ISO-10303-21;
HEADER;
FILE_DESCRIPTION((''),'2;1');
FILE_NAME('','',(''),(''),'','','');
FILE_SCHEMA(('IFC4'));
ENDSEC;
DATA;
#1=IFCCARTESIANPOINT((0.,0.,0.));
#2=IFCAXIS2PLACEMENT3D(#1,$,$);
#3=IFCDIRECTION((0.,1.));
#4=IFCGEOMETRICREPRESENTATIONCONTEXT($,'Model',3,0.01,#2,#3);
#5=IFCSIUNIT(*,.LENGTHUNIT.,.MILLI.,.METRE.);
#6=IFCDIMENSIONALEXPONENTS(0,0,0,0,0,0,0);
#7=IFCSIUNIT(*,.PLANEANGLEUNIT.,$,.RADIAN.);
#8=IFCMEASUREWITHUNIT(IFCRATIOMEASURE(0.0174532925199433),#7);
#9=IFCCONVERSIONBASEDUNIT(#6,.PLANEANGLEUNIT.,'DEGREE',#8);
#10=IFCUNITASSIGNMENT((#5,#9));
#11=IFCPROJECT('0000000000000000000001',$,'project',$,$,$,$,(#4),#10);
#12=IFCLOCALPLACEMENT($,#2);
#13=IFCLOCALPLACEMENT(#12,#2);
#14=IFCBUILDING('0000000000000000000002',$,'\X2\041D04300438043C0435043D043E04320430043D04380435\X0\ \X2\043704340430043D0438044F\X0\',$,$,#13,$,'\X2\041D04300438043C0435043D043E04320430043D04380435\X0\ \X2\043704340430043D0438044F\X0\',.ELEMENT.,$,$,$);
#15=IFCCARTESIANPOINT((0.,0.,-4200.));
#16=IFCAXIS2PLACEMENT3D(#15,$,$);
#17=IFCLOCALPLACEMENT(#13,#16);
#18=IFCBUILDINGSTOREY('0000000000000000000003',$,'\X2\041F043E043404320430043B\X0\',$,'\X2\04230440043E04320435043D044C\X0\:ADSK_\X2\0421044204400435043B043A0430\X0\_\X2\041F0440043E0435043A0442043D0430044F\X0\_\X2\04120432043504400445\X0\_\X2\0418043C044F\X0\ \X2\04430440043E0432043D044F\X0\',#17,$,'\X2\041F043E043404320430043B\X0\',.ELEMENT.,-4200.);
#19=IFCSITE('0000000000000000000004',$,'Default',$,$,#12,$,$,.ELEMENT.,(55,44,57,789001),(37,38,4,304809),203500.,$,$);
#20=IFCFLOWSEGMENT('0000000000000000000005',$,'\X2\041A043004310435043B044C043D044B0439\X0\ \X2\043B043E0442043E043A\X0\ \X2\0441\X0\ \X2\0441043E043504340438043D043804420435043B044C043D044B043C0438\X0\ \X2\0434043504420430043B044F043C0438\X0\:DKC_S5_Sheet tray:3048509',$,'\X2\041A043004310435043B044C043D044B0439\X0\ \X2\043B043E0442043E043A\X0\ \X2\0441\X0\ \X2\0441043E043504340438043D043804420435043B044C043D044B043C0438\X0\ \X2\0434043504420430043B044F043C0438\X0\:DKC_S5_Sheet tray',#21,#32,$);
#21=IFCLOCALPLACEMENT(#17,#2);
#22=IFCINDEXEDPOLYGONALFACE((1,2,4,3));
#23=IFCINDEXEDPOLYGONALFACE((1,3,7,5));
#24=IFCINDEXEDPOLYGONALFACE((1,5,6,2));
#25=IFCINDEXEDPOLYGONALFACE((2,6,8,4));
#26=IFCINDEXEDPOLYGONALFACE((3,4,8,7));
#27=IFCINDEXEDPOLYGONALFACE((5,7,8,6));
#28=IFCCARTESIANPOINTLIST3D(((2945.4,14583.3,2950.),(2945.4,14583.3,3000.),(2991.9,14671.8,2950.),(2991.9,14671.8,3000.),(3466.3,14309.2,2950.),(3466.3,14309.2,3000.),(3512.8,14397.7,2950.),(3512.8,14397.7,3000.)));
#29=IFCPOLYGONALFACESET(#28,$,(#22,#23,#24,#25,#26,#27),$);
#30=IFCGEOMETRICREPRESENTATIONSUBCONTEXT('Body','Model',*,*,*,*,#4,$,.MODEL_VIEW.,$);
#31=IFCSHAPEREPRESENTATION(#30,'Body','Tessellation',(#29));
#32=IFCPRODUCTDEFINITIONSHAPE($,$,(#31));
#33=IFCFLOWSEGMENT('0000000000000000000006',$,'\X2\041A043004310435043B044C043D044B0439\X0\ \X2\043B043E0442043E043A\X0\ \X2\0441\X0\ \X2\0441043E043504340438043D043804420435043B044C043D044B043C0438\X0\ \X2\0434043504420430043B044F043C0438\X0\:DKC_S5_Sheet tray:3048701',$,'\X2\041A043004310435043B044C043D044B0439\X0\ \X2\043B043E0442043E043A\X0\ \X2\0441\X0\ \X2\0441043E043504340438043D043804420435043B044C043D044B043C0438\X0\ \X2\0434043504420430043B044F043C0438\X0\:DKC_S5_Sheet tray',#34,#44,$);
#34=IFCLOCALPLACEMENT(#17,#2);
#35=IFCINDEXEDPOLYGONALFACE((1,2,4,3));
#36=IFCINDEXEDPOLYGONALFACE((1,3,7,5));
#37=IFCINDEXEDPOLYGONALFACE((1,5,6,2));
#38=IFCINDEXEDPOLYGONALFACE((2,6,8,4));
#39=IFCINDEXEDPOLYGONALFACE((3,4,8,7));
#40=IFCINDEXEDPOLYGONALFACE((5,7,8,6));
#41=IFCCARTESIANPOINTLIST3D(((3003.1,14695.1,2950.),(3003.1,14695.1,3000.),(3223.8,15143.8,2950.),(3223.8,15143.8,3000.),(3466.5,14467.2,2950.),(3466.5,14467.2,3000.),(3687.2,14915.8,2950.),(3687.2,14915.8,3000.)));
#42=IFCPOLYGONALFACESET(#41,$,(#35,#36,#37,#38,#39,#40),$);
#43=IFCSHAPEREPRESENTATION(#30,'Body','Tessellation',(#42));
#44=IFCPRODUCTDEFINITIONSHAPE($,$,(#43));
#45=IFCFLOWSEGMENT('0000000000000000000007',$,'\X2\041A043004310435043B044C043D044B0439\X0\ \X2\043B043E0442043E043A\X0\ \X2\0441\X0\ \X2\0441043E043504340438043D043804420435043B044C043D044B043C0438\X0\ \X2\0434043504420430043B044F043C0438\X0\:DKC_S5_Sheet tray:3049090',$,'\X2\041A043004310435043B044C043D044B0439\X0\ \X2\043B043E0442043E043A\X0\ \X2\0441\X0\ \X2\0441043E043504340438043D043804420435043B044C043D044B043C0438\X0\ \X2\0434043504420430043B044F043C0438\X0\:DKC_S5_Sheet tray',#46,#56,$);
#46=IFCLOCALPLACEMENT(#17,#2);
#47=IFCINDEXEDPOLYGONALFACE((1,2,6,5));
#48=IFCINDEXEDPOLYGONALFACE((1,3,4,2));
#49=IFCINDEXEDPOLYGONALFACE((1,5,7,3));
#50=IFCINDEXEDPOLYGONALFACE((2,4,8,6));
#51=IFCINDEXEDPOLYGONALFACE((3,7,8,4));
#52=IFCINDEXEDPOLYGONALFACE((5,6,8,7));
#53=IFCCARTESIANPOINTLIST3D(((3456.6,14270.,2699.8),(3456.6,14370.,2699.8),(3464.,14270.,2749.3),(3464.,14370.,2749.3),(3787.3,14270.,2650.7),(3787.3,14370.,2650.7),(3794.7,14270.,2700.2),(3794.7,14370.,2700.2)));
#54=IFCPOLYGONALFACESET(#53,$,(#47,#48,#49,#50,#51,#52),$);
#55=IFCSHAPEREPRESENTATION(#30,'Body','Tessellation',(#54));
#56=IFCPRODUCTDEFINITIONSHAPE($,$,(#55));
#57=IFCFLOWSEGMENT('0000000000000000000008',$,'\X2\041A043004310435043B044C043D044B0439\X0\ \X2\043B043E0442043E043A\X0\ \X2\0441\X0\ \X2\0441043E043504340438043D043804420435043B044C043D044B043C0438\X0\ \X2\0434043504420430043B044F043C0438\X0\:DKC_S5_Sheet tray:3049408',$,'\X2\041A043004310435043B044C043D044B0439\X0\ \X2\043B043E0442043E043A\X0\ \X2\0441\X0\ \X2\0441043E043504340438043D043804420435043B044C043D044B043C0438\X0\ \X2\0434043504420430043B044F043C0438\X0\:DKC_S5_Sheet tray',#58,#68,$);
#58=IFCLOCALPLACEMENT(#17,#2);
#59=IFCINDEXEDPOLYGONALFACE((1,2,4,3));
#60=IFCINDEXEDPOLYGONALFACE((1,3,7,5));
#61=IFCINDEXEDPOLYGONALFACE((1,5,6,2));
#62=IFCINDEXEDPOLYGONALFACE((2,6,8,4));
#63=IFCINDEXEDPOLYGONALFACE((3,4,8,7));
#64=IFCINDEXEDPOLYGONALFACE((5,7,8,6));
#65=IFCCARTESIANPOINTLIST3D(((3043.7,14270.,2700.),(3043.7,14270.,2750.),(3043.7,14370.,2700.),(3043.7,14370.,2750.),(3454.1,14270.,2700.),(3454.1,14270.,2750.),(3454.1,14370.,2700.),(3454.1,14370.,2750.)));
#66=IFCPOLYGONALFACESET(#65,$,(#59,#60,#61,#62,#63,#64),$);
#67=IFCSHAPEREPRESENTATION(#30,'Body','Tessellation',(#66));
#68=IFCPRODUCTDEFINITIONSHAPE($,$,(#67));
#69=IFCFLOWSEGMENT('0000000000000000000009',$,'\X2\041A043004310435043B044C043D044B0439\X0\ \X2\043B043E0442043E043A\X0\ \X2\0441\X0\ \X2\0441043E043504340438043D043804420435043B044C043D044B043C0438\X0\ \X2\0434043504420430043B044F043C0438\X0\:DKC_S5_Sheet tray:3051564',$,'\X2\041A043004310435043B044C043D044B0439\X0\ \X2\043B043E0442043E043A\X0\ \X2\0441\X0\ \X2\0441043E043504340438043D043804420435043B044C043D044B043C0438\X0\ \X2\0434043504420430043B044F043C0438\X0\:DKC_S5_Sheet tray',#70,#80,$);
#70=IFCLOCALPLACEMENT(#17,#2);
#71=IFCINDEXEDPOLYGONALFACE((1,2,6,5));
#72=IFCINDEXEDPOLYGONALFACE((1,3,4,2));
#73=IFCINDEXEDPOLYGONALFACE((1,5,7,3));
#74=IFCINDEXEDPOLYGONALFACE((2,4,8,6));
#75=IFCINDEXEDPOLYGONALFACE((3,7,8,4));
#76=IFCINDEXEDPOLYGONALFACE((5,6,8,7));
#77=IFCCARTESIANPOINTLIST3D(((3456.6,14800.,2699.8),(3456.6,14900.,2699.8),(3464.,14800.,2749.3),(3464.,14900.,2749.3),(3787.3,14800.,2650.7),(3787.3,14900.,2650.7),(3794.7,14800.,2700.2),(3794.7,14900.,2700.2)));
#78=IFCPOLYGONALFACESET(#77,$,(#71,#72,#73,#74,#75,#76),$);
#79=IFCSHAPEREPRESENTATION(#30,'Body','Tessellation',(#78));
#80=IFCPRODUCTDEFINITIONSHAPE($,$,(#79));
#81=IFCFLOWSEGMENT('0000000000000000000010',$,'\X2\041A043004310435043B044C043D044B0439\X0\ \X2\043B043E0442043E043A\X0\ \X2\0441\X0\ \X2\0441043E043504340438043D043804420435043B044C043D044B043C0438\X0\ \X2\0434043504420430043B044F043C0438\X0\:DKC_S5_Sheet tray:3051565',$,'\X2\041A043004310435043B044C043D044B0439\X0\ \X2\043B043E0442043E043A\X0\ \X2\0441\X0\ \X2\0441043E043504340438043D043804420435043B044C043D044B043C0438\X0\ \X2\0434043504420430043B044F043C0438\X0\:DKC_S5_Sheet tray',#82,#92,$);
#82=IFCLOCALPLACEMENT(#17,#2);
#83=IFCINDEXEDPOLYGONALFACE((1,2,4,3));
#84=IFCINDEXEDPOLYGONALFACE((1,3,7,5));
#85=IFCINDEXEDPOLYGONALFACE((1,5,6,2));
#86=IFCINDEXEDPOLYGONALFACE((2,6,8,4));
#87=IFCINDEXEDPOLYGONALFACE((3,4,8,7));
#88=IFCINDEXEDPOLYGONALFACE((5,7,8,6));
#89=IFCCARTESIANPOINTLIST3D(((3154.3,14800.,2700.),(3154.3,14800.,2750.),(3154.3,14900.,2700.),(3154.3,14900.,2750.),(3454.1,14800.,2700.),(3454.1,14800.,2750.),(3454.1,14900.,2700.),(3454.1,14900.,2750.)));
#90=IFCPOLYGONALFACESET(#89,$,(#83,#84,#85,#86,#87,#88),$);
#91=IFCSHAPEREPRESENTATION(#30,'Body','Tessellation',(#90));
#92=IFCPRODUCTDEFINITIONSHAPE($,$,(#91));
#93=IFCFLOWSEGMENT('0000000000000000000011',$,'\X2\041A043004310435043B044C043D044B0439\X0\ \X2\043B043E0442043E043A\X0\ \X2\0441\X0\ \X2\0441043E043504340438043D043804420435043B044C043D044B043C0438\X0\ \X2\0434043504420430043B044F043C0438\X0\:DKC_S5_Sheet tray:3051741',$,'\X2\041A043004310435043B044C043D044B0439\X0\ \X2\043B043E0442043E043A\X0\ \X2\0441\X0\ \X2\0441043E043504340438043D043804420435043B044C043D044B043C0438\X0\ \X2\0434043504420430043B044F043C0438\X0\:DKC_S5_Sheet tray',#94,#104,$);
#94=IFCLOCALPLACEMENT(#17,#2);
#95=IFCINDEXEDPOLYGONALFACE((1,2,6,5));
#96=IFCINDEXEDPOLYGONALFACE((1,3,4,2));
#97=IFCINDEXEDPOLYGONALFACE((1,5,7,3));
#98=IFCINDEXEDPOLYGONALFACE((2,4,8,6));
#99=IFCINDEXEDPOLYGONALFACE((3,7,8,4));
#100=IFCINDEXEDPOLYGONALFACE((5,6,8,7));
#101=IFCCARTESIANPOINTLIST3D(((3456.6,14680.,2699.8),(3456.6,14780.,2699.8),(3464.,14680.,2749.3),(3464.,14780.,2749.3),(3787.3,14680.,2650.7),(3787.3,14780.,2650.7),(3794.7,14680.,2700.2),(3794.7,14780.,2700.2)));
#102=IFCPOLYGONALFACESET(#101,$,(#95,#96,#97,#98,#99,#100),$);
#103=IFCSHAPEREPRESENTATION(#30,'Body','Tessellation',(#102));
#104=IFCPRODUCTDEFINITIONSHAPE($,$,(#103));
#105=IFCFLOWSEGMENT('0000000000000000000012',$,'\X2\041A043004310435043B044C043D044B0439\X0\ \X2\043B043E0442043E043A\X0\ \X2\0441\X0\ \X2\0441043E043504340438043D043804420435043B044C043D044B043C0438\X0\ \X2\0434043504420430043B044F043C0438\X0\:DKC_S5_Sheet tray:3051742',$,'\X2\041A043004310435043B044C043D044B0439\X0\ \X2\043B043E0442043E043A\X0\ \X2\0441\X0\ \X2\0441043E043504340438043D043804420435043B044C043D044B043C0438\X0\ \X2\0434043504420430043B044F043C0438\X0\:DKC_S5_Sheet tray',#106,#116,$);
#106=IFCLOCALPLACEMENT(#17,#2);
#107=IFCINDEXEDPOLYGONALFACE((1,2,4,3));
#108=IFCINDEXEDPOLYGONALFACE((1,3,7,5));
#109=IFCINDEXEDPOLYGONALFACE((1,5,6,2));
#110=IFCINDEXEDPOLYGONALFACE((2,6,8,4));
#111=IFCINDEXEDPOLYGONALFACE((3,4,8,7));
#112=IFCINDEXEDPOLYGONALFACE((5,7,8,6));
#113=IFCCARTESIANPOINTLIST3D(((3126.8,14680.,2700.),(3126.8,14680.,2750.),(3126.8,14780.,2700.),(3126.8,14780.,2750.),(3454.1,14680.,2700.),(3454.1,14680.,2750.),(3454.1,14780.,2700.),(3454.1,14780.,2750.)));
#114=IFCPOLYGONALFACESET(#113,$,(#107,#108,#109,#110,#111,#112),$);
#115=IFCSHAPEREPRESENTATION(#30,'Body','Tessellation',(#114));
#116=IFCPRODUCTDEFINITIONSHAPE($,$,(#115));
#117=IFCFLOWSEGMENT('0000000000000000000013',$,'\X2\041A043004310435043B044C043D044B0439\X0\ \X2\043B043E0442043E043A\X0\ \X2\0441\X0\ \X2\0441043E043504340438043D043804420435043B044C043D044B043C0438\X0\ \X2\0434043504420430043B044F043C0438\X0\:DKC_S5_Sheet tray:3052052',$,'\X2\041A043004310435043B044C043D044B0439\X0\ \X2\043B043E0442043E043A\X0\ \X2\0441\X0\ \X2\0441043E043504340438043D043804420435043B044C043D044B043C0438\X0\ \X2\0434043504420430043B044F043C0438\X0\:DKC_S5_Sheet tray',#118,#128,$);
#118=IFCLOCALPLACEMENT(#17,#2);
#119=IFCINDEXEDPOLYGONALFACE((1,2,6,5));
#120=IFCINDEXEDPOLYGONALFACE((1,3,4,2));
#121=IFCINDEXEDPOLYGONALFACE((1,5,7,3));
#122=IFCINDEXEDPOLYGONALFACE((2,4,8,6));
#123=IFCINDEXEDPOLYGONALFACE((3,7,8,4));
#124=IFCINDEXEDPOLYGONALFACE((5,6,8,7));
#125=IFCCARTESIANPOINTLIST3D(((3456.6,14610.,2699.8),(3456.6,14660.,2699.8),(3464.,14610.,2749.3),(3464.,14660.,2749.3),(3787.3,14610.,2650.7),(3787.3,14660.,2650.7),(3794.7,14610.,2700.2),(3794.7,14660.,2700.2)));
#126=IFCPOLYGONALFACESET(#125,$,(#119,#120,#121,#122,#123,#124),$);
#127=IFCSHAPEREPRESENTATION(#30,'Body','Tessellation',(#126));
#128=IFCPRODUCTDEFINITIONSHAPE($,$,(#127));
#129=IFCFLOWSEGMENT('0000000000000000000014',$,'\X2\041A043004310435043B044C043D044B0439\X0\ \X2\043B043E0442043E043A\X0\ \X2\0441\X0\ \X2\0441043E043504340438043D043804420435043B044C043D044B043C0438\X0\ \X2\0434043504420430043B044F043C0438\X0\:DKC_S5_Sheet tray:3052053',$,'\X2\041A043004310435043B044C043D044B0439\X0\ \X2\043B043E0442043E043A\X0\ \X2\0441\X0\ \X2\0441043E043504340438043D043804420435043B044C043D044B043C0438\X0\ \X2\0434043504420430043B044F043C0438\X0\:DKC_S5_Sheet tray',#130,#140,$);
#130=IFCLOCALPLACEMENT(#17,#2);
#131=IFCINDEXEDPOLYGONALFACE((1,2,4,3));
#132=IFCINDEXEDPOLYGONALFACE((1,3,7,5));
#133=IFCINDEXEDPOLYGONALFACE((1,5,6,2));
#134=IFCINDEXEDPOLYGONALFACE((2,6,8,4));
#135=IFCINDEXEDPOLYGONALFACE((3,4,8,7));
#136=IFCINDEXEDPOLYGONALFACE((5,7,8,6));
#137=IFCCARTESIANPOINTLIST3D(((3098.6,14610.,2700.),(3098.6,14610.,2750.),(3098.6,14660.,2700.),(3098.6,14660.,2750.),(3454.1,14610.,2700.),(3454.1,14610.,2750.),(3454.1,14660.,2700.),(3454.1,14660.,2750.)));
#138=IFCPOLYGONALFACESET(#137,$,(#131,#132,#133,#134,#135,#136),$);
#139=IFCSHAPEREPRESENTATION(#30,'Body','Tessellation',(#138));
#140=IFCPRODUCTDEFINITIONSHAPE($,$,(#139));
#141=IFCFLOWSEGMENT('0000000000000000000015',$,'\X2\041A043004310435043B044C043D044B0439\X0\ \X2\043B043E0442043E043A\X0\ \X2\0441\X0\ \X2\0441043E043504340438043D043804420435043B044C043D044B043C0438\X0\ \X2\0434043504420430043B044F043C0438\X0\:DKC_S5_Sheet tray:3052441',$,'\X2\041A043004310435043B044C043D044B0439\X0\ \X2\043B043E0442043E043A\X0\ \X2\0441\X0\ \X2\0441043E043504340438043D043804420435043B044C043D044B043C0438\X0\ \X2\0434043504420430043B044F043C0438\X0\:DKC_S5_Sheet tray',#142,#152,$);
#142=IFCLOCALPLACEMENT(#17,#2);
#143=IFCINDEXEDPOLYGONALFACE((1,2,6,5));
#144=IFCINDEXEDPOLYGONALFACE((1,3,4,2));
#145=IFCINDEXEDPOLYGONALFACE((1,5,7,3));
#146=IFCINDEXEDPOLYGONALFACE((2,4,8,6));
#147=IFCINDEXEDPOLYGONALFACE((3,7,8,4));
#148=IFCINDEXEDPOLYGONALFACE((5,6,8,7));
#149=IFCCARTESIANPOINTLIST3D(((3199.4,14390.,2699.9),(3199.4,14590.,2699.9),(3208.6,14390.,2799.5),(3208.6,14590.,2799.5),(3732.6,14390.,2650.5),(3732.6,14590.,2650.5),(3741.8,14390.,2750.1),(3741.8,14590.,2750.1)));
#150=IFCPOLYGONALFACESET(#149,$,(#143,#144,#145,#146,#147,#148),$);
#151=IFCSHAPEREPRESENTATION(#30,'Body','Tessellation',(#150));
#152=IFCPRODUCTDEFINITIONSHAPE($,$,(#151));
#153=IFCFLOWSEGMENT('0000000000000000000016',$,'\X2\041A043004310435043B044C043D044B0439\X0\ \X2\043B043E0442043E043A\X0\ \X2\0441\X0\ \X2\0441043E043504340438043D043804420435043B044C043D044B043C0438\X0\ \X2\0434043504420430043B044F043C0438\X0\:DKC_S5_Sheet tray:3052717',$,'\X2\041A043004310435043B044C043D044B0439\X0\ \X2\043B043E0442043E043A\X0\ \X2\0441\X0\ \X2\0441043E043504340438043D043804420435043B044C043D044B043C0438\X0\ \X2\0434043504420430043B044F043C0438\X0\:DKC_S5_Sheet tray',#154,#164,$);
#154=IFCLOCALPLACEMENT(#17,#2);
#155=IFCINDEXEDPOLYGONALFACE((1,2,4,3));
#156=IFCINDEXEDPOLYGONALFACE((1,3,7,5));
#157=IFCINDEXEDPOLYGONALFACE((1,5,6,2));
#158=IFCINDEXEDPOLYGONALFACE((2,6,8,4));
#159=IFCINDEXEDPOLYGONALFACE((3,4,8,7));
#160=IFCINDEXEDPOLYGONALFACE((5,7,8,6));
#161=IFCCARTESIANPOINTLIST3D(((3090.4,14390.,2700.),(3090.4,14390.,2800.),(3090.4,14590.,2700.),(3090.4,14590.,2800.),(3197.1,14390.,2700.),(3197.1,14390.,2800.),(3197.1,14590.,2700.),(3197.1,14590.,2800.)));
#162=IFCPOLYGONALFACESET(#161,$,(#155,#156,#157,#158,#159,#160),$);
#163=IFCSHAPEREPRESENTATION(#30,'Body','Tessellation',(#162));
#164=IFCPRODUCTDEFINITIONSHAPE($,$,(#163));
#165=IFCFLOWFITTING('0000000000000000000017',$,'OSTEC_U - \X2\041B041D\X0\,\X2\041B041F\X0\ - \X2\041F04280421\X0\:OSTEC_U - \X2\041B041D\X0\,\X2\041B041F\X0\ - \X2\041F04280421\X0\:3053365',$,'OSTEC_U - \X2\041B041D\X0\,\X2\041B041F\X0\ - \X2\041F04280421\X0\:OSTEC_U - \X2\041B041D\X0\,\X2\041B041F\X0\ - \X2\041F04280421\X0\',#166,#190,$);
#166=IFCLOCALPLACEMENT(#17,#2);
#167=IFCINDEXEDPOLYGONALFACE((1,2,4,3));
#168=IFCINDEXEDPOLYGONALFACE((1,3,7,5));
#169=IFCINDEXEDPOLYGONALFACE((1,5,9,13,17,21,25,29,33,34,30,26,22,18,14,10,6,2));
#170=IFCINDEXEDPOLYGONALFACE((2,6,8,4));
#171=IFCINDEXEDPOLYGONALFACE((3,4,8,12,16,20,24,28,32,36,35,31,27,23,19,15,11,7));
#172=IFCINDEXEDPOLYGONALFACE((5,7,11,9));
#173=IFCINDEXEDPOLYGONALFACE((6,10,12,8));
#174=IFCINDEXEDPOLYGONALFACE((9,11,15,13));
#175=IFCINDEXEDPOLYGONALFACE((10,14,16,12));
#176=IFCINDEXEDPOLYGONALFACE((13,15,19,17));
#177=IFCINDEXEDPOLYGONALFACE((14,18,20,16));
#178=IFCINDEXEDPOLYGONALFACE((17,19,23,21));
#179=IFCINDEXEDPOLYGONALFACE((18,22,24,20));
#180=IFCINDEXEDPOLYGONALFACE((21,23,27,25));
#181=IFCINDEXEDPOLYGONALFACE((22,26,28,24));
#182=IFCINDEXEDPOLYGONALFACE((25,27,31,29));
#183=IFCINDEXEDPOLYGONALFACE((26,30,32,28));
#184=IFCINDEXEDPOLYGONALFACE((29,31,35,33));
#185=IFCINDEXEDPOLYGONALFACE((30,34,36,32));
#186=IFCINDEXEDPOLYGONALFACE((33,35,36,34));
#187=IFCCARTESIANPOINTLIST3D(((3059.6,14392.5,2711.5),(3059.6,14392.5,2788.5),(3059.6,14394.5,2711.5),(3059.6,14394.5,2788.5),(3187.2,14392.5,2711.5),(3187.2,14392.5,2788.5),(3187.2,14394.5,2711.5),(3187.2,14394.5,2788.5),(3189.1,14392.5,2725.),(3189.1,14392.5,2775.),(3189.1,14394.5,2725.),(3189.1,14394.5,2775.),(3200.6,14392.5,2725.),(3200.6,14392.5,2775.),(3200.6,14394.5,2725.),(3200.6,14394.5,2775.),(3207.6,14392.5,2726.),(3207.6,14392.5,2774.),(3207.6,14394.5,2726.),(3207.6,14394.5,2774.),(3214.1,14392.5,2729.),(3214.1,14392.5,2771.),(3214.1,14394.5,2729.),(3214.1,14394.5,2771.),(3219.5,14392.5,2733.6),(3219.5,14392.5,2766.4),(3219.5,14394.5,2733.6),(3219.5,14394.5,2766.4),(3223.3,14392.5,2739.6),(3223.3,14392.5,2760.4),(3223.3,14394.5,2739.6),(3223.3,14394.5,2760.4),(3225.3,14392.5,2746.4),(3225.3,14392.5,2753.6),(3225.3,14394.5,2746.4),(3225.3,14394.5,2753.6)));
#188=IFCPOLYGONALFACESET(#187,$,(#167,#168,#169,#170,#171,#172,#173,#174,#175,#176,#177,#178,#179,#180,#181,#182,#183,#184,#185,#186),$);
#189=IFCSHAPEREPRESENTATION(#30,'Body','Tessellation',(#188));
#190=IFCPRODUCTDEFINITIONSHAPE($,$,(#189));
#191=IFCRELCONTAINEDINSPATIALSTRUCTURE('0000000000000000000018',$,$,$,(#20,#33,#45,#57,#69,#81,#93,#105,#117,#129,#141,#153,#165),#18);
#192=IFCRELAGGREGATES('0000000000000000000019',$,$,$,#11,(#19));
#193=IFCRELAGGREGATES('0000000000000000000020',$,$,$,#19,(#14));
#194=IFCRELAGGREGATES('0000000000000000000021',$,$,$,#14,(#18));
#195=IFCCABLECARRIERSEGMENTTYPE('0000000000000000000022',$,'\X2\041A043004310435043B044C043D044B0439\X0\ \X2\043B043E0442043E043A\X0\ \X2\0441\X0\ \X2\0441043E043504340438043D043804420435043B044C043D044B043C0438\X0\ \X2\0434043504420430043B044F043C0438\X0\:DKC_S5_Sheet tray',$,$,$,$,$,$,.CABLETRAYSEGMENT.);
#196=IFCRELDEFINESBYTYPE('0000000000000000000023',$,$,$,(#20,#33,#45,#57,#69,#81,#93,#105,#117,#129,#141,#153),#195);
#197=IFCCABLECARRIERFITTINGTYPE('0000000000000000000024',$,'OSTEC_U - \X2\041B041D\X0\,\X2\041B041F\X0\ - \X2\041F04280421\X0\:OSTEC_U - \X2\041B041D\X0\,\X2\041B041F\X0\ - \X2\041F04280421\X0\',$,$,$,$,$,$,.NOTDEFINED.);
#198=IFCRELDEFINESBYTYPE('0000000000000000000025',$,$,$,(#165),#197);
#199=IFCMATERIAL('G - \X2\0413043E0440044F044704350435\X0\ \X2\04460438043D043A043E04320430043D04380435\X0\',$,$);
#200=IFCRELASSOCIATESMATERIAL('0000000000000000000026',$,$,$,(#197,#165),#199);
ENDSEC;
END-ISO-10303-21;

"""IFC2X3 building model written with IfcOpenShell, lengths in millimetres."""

from ifc_helpers import new_model, entity, si_unit, converted_unit, direction, frame, frame_2d, origin, origin_2d_with_axis, place, context, subcontext, project, spatial, polyline, circle_curve, parameter, trimmed, segment, composite_curve, rectangle, outline, extrude, source, transform, mapped, material, type_object, type_shapes, element, save


model = new_model("IFC2X3")

# Units and contexts
model_context = context("Model", 3, precision=0.01, world=origin(), true_north=direction((0.0, 1.0)))
body_context = subcontext(model_context, "Body", "Model", "MODEL_VIEW")
ifc_project = project(units=[si_unit("LENGTHUNIT", "METRE", prefix="MILLI"), converted_unit("PLANEANGLEUNIT", "DEGREE", entity("IfcRatioMeasure", 0.0174532925199433), si_unit("PLANEANGLEUNIT", "RADIAN"), dimensions=[0, 0, 0, 0, 0, 0, 0])], contexts=[model_context])

# Site, building, storey
site_placement = place(None, origin())
site = spatial("IfcSite", under=ifc_project, at=site_placement, Name="Default", CompositionType="ELEMENT", RefLatitude=(55, 44, 57, 789001), RefLongitude=(37, 38, 4, 304809), RefElevation=203500.0)
building_placement = place(site_placement, origin())
building = spatial("IfcBuilding", under=site, at=building_placement, Name="Наименование здания", LongName="Наименование здания", CompositionType="ELEMENT")
storey_placement = place(building_placement, frame((0.0, 0.0, -4200.0)))
storey = spatial("IfcBuildingStorey", under=building, at=storey_placement, Name="Подвал", ObjectType="Уровень:ADSK_Стрелка_Проектная_Вверх_Имя уровня", LongName="Подвал", CompositionType="ELEMENT", Elevation=-4200.0)

# Flow segments
cable_carrier_segment_type = type_object("IfcCableCarrierSegmentType", Name="Кабельный лоток с соединительными деталями:DKC_S5_Sheet tray", PredefinedType="CABLETRAYSEGMENT")
flow_segment_1_placement = place(storey_placement, frame((2945.4, 14309.2, 2950.0)))
element("IfcFlowSegment", 1, at=flow_segment_1_placement, inside=storey, type_object=cable_carrier_segment_type, Name="Кабельный лоток с соединительными деталями:DKC_S5_Sheet tray:3048509", ObjectType="Кабельный лоток с соединительными деталями:DKC_S5_Sheet tray", context=body_context, shape_type="SweptSolid", body=[
    extrude(rectangle(XDim=588.6, YDim=100.0, at=origin_2d_with_axis()), frame((283.7, 181.3, 0.0), z_axis=(0.0, 0.0, 1.0), x_axis=(0.885007, -0.465578, 0.0)), (0.0, 0.0, 1.0), 50.0),
])
flow_segment_2_placement = place(storey_placement, frame((3003.1, 14467.2, 2950.0)))
element("IfcFlowSegment", 2, at=flow_segment_2_placement, inside=storey, type_object=cable_carrier_segment_type, Name="Кабельный лоток с соединительными деталями:DKC_S5_Sheet tray:3048701", ObjectType="Кабельный лоток с соединительными деталями:DKC_S5_Sheet tray", context=body_context, shape_type="SweptSolid", body=[
    extrude(rectangle(XDim=516.5, YDim=500.0, at=origin_2d_with_axis()), frame((342.1, 338.3, 0.0), z_axis=(0.0, 0.0, 1.0), x_axis=(0.897336, -0.441348, 0.0)), (0.0, 0.0, 1.0), 50.0),
])
flow_segment_3_placement = place(storey_placement, frame((3456.6, 14270.0, 2650.7)))
element("IfcFlowSegment", 3, at=flow_segment_3_placement, inside=storey, type_object=cable_carrier_segment_type, Name="Кабельный лоток с соединительными деталями:DKC_S5_Sheet tray:3049090", ObjectType="Кабельный лоток с соединительными деталями:DKC_S5_Sheet tray", context=body_context, shape_type="SweptSolid", body=[
    extrude(rectangle(XDim=50.0, YDim=100.0, at=origin_2d_with_axis()), frame((3.7, 50.0, 73.8), z_axis=(0.989166, 0.0, -0.1468), x_axis=(0.1468, 0.0, 0.989166)), (0.0, 0.0, 1.0), 334.3),
])
flow_segment_4_placement = place(storey_placement, frame((3043.8, 14270.0, 2700.0)))
element("IfcFlowSegment", 4, at=flow_segment_4_placement, inside=storey, type_object=cable_carrier_segment_type, Name="Кабельный лоток с соединительными деталями:DKC_S5_Sheet tray:3049408", ObjectType="Кабельный лоток с соединительными деталями:DKC_S5_Sheet tray", context=body_context, shape_type="SweptSolid", body=[
    extrude(rectangle(XDim=410.3, YDim=100.0, at=origin_2d_with_axis()), frame((205.2, 50.0, 0.0), z_axis=(0.0, 0.0, 1.0), x_axis=(-1.0, 0.0, 0.0)), (0.0, 0.0, 1.0), 50.0),
])
flow_segment_5_placement = place(storey_placement, frame((3456.6, 14800.0, 2650.7)))
element("IfcFlowSegment", 5, at=flow_segment_5_placement, inside=storey, type_object=cable_carrier_segment_type, Name="Кабельный лоток с соединительными деталями:DKC_S5_Sheet tray:3051564", ObjectType="Кабельный лоток с соединительными деталями:DKC_S5_Sheet tray", context=body_context, shape_type="SweptSolid", body=[
    extrude(rectangle(XDim=50.0, YDim=100.0, at=origin_2d_with_axis()), frame((3.7, 50.0, 73.8), z_axis=(0.989166, 0.0, -0.1468), x_axis=(0.1468, 0.0, 0.989166)), (0.0, 0.0, 1.0), 334.3),
])
flow_segment_6_placement = place(storey_placement, frame((3154.3, 14800.0, 2700.0)))
element("IfcFlowSegment", 6, at=flow_segment_6_placement, inside=storey, type_object=cable_carrier_segment_type, Name="Кабельный лоток с соединительными деталями:DKC_S5_Sheet tray:3051565", ObjectType="Кабельный лоток с соединительными деталями:DKC_S5_Sheet tray", context=body_context, shape_type="SweptSolid", body=[
    extrude(rectangle(XDim=299.7, YDim=100.0, at=origin_2d_with_axis()), frame((149.9, 50.0, 0.0), z_axis=(0.0, 0.0, 1.0), x_axis=(-1.0, 0.0, 0.0)), (0.0, 0.0, 1.0), 50.0),
])
flow_segment_7_placement = place(storey_placement, frame((3456.6, 14680.0, 2650.7)))
element("IfcFlowSegment", 7, at=flow_segment_7_placement, inside=storey, type_object=cable_carrier_segment_type, Name="Кабельный лоток с соединительными деталями:DKC_S5_Sheet tray:3051741", ObjectType="Кабельный лоток с соединительными деталями:DKC_S5_Sheet tray", context=body_context, shape_type="SweptSolid", body=[
    extrude(rectangle(XDim=50.0, YDim=100.0, at=origin_2d_with_axis()), frame((3.7, 50.0, 73.8), z_axis=(0.989166, 0.0, -0.1468), x_axis=(0.1468, 0.0, 0.989166)), (0.0, 0.0, 1.0), 334.3),
])
flow_segment_8_placement = place(storey_placement, frame((3126.8, 14680.0, 2700.0)))
element("IfcFlowSegment", 8, at=flow_segment_8_placement, inside=storey, type_object=cable_carrier_segment_type, Name="Кабельный лоток с соединительными деталями:DKC_S5_Sheet tray:3051742", ObjectType="Кабельный лоток с соединительными деталями:DKC_S5_Sheet tray", context=body_context, shape_type="SweptSolid", body=[
    extrude(rectangle(XDim=327.2, YDim=100.0, at=origin_2d_with_axis()), frame((163.6, 50.0, 0.0), z_axis=(0.0, 0.0, 1.0), x_axis=(-1.0, 0.0, 0.0)), (0.0, 0.0, 1.0), 50.0),
])
flow_segment_9_placement = place(storey_placement, frame((3456.6, 14610.0, 2650.7)))
element("IfcFlowSegment", 9, at=flow_segment_9_placement, inside=storey, type_object=cable_carrier_segment_type, Name="Кабельный лоток с соединительными деталями:DKC_S5_Sheet tray:3052052", ObjectType="Кабельный лоток с соединительными деталями:DKC_S5_Sheet tray", context=body_context, shape_type="SweptSolid", body=[
    extrude(rectangle(XDim=50.0, YDim=50.0, at=origin_2d_with_axis()), frame((3.7, 25.0, 73.8), z_axis=(0.989166, 0.0, -0.1468), x_axis=(0.1468, 0.0, 0.989166)), (0.0, 0.0, 1.0), 334.3),
])
flow_segment_10_placement = place(storey_placement, frame((3098.6, 14610.0, 2700.0)))
element("IfcFlowSegment", 10, at=flow_segment_10_placement, inside=storey, type_object=cable_carrier_segment_type, Name="Кабельный лоток с соединительными деталями:DKC_S5_Sheet tray:3052053", ObjectType="Кабельный лоток с соединительными деталями:DKC_S5_Sheet tray", context=body_context, shape_type="SweptSolid", body=[
    extrude(rectangle(XDim=355.5, YDim=50.0, at=origin_2d_with_axis()), frame((177.7, 25.0, 0.0), z_axis=(0.0, 0.0, 1.0), x_axis=(-1.0, 0.0, 0.0)), (0.0, 0.0, 1.0), 50.0),
])
flow_segment_11_placement = place(storey_placement, frame((3199.4, 14390.0, 2650.5)))
element("IfcFlowSegment", 11, at=flow_segment_11_placement, inside=storey, type_object=cable_carrier_segment_type, Name="Кабельный лоток с соединительными деталями:DKC_S5_Sheet tray:3052441", ObjectType="Кабельный лоток с соединительными деталями:DKC_S5_Sheet tray", context=body_context, shape_type="SweptSolid", body=[
    extrude(rectangle(XDim=100.0, YDim=200.0, at=origin_2d_with_axis()), frame((4.6, 100.0, 99.1), z_axis=(0.995742, 0.0, -0.092183), x_axis=(0.092183, 0.0, 0.995742)), (0.0, 0.0, 1.0), 535.4),
])
flow_segment_12_placement = place(storey_placement, frame((3090.4, 14390.0, 2700.0)))
element("IfcFlowSegment", 12, at=flow_segment_12_placement, inside=storey, type_object=cable_carrier_segment_type, Name="Кабельный лоток с соединительными деталями:DKC_S5_Sheet tray:3052717", ObjectType="Кабельный лоток с соединительными деталями:DKC_S5_Sheet tray", context=body_context, shape_type="SweptSolid", body=[
    extrude(rectangle(XDim=106.6, YDim=200.0, at=origin_2d_with_axis()), frame((53.3, 100.0, 0.0), z_axis=(0.0, 0.0, 1.0), x_axis=(-1.0, 0.0, 0.0)), (0.0, 0.0, 1.0), 100.0),
])

# Flow fitting
ifc_material_1 = material(Name="G - Горячее цинкование")
cable_carrier_fitting_type_1 = type_object("IfcCableCarrierFittingType", Name="OSTEC_U - ЛН,ЛП - ПШС:OSTEC_U - ЛН,ЛП - ПШС", PredefinedType="NOTDEFINED", material=ifc_material_1)
shared_shape_1 = source(origin(), body_context, "Body", "SweptSolid", [
    extrude(outline(composite_curve([segment(trimmed(circle_curve(frame_2d((-41.5, 0.0), x_axis=(1.0, 0.0)), 25.0), [parameter(90.0)], [parameter(270.0)], True, "PARAMETER"), True, "CONTINUOUS"), segment(polyline([(-41.5, -25.0), (-30.0, -25.0)]), True, "CONTINUOUS"), segment(polyline([(-30.0, -25.0), (-28.1, -38.5)]), True, "CONTINUOUS"), segment(polyline([(-28.1, -38.5), (99.5, -38.5)]), True, "CONTINUOUS"), segment(polyline([(99.5, -38.5), (99.5, 38.5)]), True, "CONTINUOUS"), segment(polyline([(99.5, 38.5), (-28.1, 38.5)]), True, "CONTINUOUS"), segment(polyline([(-28.1, 38.5), (-30.0, 25.0)]), True, "CONTINUOUS"), segment(polyline([(-30.0, 25.0), (-41.5, 25.0)]), True, "CONTINUOUS")], self_intersect=False)), frame((41.5, 0.0, 0.0), z_axis=(0.0, 0.0, -1.0), x_axis=(1.0, 0.0, 0.0)), (0.0, 0.0, -1.0), 2.0),
])
type_shapes(cable_carrier_fitting_type_1, [shared_shape_1])
flow_fitting_1_placement = place(storey_placement, frame((3200.6, 14394.5, 2750.0), z_axis=(0.0, -1.0, 0.0), x_axis=(-1.0, 0.0, 0.0)))
element("IfcFlowFitting", 13, at=flow_fitting_1_placement, inside=storey, type_object=cable_carrier_fitting_type_1, material=ifc_material_1, Name="OSTEC_U - ЛН,ЛП - ПШС:OSTEC_U - ЛН,ЛП - ПШС:3053365", ObjectType="OSTEC_U - ЛН,ЛП - ПШС:OSTEC_U - ЛН,ЛП - ПШС", context=body_context, shape_type="MappedRepresentation", body=[
    mapped(shared_shape_1, transform((0.0, 0.0, 0.0), scale=1.0)),
])

save(model, "model.ifc")
